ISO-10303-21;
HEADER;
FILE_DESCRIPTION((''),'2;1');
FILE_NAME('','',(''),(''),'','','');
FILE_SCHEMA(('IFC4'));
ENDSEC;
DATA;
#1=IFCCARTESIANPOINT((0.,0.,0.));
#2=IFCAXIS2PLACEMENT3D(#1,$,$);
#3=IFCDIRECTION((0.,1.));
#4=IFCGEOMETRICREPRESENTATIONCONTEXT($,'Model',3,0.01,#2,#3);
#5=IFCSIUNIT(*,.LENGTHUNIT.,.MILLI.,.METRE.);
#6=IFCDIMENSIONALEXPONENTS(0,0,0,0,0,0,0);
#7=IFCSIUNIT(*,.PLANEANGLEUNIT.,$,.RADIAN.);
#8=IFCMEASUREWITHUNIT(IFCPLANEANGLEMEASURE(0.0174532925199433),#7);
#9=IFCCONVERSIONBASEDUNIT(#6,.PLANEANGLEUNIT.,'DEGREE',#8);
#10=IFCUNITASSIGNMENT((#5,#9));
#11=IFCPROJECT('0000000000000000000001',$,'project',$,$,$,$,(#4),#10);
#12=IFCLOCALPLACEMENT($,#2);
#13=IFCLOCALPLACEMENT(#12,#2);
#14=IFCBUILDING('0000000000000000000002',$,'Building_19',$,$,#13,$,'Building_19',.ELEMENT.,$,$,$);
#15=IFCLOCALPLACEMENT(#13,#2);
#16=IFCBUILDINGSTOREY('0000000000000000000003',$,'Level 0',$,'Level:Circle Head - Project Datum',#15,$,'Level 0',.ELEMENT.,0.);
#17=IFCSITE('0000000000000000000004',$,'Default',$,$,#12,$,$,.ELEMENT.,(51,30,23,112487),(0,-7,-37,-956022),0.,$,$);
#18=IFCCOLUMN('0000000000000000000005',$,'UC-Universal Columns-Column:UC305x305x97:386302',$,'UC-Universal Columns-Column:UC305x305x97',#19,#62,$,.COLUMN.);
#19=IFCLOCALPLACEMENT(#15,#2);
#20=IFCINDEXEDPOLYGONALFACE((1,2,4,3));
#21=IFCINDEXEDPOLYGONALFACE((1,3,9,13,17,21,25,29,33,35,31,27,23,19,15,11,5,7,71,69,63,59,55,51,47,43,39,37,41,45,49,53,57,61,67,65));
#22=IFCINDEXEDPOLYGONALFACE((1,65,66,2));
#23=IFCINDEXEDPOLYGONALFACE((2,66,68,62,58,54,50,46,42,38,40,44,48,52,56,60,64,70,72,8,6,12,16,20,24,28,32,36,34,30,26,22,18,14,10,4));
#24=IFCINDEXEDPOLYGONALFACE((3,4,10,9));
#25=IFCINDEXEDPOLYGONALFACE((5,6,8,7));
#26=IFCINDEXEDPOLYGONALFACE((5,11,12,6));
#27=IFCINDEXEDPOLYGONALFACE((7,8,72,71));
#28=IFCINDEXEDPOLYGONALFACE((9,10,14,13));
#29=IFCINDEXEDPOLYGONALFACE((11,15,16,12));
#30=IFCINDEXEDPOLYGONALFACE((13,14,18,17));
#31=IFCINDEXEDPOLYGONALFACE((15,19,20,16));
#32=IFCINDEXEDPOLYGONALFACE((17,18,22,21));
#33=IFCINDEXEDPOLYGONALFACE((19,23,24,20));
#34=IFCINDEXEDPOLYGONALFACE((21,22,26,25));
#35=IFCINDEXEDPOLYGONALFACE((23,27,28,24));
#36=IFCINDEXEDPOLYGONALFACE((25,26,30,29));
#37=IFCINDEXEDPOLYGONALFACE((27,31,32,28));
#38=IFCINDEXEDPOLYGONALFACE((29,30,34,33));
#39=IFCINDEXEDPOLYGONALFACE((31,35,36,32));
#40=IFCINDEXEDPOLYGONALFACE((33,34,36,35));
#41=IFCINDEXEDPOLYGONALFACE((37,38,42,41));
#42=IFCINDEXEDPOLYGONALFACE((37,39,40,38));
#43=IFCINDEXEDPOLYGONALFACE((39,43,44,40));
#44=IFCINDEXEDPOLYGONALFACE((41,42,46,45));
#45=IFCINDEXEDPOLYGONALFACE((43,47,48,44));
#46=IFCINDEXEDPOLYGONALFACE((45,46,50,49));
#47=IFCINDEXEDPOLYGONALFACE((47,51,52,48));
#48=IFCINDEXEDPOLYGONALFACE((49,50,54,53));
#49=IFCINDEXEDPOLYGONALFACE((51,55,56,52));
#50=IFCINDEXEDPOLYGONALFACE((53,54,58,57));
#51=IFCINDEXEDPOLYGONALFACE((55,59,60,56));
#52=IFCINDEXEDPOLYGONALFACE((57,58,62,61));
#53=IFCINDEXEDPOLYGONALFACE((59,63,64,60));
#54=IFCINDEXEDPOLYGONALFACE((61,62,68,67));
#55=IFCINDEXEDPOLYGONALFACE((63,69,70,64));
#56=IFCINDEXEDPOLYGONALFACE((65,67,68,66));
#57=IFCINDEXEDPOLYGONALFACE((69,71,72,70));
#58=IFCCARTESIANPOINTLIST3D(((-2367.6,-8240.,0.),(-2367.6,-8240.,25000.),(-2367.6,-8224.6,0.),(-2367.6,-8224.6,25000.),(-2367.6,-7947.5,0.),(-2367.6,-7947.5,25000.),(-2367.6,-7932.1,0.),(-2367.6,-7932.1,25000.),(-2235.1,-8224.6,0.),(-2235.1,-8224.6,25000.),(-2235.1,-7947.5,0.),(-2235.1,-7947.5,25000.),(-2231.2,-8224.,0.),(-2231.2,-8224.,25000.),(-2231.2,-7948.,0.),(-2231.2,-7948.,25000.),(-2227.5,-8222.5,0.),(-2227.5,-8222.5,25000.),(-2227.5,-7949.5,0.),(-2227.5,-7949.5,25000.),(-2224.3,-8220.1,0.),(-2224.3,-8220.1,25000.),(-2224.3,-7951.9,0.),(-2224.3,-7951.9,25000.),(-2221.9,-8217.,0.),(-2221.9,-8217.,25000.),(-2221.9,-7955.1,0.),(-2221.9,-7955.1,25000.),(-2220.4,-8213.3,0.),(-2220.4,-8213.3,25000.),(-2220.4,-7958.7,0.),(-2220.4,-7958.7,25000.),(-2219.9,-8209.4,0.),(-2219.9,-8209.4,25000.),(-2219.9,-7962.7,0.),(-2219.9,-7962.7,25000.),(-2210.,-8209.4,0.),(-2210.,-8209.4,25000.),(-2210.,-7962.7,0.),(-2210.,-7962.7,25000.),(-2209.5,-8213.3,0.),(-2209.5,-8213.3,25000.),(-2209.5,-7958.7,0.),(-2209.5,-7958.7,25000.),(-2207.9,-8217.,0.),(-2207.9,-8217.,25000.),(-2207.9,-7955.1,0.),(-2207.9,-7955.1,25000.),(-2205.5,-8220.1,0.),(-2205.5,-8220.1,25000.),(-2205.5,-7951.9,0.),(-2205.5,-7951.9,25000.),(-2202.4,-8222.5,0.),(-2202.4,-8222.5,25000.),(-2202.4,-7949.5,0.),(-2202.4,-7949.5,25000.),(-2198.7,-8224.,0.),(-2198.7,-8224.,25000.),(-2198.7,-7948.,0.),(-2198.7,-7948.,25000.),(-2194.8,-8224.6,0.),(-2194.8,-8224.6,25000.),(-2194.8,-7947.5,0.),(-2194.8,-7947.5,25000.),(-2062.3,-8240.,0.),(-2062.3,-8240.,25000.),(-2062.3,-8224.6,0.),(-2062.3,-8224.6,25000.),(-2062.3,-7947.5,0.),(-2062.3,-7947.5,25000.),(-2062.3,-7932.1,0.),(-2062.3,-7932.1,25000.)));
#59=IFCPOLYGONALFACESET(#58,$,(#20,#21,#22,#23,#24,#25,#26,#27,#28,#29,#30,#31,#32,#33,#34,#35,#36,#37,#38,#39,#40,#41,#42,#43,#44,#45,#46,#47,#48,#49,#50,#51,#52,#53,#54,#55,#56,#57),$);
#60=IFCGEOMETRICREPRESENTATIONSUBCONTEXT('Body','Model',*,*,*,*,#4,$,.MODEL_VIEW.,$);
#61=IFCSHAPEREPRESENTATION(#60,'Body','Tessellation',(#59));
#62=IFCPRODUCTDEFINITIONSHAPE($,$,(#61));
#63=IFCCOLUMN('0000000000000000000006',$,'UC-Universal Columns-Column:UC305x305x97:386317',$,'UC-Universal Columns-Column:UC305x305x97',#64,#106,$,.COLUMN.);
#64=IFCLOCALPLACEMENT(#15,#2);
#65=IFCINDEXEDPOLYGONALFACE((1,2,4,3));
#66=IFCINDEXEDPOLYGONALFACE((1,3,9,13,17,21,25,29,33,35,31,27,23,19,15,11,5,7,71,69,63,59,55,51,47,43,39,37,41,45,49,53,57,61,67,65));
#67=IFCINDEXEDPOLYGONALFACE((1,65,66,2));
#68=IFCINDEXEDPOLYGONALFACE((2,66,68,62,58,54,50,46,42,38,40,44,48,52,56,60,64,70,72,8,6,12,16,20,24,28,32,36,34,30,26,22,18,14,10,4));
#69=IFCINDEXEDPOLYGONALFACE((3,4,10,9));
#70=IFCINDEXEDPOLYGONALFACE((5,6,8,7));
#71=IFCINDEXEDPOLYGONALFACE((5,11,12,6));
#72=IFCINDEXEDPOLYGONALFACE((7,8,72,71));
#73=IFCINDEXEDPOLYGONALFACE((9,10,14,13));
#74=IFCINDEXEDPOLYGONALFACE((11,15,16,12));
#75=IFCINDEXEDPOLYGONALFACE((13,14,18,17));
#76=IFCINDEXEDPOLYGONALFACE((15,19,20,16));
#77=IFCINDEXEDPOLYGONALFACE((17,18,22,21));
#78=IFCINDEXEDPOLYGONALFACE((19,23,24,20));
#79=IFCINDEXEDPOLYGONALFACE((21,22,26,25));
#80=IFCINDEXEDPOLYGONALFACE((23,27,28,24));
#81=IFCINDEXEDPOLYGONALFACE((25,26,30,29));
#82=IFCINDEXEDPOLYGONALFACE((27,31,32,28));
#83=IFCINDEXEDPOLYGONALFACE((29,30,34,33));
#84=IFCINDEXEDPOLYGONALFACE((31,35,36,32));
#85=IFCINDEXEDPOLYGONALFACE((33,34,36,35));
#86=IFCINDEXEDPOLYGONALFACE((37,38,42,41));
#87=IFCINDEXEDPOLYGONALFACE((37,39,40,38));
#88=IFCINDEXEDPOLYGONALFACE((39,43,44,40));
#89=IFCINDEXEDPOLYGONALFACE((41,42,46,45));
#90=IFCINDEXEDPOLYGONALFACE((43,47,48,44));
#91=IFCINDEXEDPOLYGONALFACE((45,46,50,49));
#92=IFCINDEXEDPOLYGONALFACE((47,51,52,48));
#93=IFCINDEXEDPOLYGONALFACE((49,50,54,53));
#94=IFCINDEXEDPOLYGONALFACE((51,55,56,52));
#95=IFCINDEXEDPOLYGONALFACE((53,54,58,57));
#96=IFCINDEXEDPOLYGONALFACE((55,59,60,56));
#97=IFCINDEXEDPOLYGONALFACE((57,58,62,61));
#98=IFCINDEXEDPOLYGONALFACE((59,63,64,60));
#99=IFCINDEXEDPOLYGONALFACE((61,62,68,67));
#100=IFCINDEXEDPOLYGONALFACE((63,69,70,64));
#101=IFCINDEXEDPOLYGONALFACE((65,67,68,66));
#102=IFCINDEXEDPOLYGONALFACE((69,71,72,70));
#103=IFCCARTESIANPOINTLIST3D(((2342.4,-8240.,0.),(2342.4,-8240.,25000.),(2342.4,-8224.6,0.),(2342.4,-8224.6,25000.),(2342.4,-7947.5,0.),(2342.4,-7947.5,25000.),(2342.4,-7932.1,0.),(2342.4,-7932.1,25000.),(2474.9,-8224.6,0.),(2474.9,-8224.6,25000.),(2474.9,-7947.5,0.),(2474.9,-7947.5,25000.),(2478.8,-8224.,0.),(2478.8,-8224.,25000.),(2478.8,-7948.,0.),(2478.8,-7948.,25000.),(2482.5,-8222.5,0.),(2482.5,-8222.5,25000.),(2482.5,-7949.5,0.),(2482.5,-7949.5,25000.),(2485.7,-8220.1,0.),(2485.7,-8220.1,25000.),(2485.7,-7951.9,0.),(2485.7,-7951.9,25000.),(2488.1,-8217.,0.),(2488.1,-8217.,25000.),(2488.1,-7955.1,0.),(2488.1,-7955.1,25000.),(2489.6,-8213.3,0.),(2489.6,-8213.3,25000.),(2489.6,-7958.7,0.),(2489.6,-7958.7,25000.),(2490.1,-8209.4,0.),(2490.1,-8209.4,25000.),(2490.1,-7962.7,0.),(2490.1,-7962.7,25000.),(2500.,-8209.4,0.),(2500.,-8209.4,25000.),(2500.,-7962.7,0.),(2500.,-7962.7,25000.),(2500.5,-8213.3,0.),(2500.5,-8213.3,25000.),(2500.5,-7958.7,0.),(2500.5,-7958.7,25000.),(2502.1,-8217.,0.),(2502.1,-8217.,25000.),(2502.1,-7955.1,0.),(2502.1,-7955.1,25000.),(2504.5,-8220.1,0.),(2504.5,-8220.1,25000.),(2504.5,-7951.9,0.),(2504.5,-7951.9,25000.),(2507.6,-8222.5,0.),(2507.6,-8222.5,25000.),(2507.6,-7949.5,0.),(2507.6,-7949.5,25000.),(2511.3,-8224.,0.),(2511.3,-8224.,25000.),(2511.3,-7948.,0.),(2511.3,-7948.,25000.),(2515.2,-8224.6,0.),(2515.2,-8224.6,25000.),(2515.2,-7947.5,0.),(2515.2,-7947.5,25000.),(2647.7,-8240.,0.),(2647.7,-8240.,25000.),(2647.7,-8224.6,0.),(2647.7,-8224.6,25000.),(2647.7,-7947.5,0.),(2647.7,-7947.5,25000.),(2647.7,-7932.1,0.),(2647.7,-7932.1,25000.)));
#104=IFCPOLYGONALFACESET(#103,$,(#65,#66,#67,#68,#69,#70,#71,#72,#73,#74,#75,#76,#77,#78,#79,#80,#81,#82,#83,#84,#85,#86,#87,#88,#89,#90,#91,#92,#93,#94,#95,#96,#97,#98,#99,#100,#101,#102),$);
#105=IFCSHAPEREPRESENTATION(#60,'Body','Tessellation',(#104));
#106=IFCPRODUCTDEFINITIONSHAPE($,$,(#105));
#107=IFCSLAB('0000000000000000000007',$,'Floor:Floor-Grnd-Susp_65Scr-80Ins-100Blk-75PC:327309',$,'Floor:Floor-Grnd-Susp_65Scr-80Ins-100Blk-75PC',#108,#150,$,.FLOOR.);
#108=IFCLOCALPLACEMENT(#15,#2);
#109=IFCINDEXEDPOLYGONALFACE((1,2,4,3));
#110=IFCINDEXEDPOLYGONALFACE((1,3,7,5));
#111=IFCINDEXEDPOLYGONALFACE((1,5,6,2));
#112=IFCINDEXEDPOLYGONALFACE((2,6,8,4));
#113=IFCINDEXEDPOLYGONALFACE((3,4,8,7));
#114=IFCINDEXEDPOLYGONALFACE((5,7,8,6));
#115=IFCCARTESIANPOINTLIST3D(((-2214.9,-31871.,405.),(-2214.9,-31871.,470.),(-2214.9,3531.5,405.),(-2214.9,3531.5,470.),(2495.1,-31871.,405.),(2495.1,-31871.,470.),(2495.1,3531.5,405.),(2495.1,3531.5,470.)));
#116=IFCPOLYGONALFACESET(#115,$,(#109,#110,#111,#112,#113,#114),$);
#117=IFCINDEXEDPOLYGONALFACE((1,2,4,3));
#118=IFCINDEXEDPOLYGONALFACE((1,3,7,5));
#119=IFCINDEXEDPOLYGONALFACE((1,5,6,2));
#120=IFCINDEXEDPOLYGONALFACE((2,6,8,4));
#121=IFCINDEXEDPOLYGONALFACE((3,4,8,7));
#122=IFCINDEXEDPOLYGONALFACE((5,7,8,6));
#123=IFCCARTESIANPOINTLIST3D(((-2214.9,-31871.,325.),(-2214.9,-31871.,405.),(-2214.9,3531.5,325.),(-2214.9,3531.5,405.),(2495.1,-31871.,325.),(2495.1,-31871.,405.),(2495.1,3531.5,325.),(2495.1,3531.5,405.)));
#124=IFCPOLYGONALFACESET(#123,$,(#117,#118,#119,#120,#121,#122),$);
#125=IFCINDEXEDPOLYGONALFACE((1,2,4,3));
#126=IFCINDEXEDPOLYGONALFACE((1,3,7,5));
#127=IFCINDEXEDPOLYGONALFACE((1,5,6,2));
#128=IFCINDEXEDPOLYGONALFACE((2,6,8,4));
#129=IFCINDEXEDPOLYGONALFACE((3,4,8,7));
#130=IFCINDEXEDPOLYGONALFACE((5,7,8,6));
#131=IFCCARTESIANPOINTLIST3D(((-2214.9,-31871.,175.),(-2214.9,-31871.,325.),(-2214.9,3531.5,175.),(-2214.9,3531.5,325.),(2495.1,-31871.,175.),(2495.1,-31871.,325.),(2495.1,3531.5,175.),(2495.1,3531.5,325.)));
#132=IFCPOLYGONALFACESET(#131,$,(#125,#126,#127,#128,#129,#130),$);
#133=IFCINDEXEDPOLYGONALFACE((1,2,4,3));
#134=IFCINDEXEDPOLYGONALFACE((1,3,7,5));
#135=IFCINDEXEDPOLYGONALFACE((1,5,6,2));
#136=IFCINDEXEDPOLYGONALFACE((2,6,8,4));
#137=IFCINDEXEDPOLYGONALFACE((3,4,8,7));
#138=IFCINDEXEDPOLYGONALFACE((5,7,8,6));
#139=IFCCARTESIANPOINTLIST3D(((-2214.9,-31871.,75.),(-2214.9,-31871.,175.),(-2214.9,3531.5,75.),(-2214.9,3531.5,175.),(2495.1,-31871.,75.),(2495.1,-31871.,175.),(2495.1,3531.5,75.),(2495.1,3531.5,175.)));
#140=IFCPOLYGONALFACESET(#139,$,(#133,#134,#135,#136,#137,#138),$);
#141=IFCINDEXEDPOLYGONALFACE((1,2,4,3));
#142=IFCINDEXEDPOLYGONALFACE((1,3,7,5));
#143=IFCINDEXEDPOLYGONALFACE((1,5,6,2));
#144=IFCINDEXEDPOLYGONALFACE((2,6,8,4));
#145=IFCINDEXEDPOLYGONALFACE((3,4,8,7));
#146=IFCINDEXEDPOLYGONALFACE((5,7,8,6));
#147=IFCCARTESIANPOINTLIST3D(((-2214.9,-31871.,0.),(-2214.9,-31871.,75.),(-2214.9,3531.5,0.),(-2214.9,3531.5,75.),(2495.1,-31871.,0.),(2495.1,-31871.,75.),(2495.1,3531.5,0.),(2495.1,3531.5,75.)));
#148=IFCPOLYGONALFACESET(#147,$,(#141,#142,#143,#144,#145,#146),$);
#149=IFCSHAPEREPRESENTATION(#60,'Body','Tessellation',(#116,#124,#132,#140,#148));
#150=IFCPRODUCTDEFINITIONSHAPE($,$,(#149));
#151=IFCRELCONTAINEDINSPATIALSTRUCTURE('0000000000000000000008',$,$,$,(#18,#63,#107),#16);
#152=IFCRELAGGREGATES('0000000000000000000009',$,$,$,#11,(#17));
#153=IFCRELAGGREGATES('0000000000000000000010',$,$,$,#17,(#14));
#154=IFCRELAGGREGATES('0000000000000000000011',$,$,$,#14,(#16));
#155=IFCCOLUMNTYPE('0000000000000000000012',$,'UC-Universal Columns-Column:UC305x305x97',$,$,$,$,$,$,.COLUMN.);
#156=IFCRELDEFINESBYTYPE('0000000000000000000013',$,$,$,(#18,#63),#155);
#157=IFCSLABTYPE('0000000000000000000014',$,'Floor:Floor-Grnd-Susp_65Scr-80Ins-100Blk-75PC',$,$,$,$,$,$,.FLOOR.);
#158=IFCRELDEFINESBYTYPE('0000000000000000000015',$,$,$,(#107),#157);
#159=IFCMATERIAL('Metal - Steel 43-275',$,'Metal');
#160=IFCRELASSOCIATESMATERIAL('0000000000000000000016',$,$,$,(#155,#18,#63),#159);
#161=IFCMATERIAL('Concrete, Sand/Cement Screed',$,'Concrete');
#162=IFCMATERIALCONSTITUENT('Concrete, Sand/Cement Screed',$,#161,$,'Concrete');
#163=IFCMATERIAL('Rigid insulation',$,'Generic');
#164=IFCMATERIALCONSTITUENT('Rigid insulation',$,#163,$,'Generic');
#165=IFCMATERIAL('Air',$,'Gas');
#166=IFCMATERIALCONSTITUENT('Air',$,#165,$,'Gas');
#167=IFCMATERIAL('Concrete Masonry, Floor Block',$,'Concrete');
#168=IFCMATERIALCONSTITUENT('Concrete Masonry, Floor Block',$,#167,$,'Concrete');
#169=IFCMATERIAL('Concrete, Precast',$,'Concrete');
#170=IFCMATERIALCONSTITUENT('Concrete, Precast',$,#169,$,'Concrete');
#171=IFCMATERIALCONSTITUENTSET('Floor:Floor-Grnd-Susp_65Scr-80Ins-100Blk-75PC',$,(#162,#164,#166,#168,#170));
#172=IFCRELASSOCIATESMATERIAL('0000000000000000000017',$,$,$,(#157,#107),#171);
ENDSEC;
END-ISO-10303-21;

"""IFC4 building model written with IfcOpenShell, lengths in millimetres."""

from ifc_helpers import new_model, entity, si_unit, converted_unit, direction, frame, origin, place, context, subcontext, project, spatial, line, arc, indexed_curve, outline, extrude, source, transform, mapped, material, constituent, constituent_set, type_object, type_shapes, element, save


model = new_model("IFC4")

# Units and contexts
model_context = context("Model", 3, precision=0.01, world=origin(), true_north=direction((0.0, 1.0)))
body_context = subcontext(model_context, "Body", "Model", "MODEL_VIEW")
ifc_project = project(units=[si_unit("LENGTHUNIT", "METRE", prefix="MILLI"), converted_unit("PLANEANGLEUNIT", "DEGREE", entity("IfcPlaneAngleMeasure", 0.0174532925199433), si_unit("PLANEANGLEUNIT", "RADIAN"), dimensions=[0, 0, 0, 0, 0, 0, 0])], contexts=[model_context])

# Site, building, storey
site_placement = place(None, origin())
site = spatial("IfcSite", under=ifc_project, at=site_placement, Name="Default", CompositionType="ELEMENT", RefLatitude=(51, 30, 23, 112487), RefLongitude=(0, -7, -37, -956022), RefElevation=0.0)
building_placement = place(site_placement, origin())
building = spatial("IfcBuilding", under=site, at=building_placement, Name="Building_19", LongName="Building_19", CompositionType="ELEMENT")
storey_placement = place(building_placement, origin())
storey = spatial("IfcBuildingStorey", under=building, at=storey_placement, Name="Level 0", ObjectType="Level:Circle Head - Project Datum", LongName="Level 0", CompositionType="ELEMENT", Elevation=0.0)

# Columns
ifc_material_1 = material(Name="Metal - Steel 43-275", Category="Metal")
column_type = type_object("IfcColumnType", Name="UC-Universal Columns-Column:UC305x305x97", PredefinedType="COLUMN", material=ifc_material_1)
shared_shape_1 = source(origin(), body_context, "Body", "SweptSolid", [
    extrude(outline(indexed_curve([(-152.7, -153.9), (152.7, -153.9), (152.7, -138.6), (20.2, -138.6), (9.4, -134.1), (4.9, -123.3), (4.9, 123.3), (9.4, 134.1), (20.1, 138.6), (152.7, 138.6), (152.7, 153.9), (-152.7, 153.9), (-152.7, 138.6), (-20.2, 138.6), (-9.4, 134.1), (-5.0, 123.3), (-5.0, -123.3), (-9.4, -134.1), (-20.2, -138.6), (-152.7, -138.6)], segments=[line(1, 2, 3, 4), arc(4, 5, 6), line(6, 7), arc(7, 8, 9), line(9, 10, 11, 12, 13, 14), arc(14, 15, 16), line(16, 17), arc(17, 18, 19), line(19, 20, 1)], self_intersect=False)), frame((0.0, 0.0, 0.0), z_axis=(0.0, 0.0, 1.0), x_axis=(-1.0, 0.0, 0.0)), (0.0, 0.0, 1.0), 25000.0),
])
type_shapes(column_type, [shared_shape_1])
for number, where, name in (
    (1, (-2214.9, -8086.0, 0.0), "UC-Universal Columns-Column:UC305x305x97:386302"),
    (2, (2495.1, -8086.0, 0.0), "UC-Universal Columns-Column:UC305x305x97:386317"),
):
    element("IfcColumn", number, at=place(storey_placement, frame(where)), inside=storey, type_object=column_type, material=ifc_material_1, Name=name, ObjectType="UC-Universal Columns-Column:UC305x305x97", PredefinedType="COLUMN", context=body_context, shape_type="MappedRepresentation", body=[
        mapped(shared_shape_1, transform((0.0, 0.0, 0.0), scale=1.0)),
    ])

# Slab
ifc_material_2 = material(Name="Concrete, Sand/Cement Screed", Category="Concrete")
ifc_constituent_1 = constituent(ifc_material_2, Name="Concrete, Sand/Cement Screed", Category="Concrete")
ifc_material_3 = material(Name="Rigid insulation", Category="Generic")
ifc_constituent_2 = constituent(ifc_material_3, Name="Rigid insulation", Category="Generic")
ifc_material_4 = material(Name="Air", Category="Gas")
ifc_constituent_3 = constituent(ifc_material_4, Name="Air", Category="Gas")
ifc_material_5 = material(Name="Concrete Masonry, Floor Block", Category="Concrete")
ifc_constituent_4 = constituent(ifc_material_5, Name="Concrete Masonry, Floor Block", Category="Concrete")
ifc_material_6 = material(Name="Concrete, Precast", Category="Concrete")
ifc_constituent_5 = constituent(ifc_material_6, Name="Concrete, Precast", Category="Concrete")
ifc_constituent_set_1 = constituent_set(constituents=[ifc_constituent_1, ifc_constituent_2, ifc_constituent_3, ifc_constituent_4, ifc_constituent_5], Name="Floor:Floor-Grnd-Susp_65Scr-80Ins-100Blk-75PC")
slab_type = type_object("IfcSlabType", Name="Floor:Floor-Grnd-Susp_65Scr-80Ins-100Blk-75PC", PredefinedType="FLOOR", material=ifc_constituent_set_1)
slab_1_placement = place(storey_placement, origin())
element("IfcSlab", 3, at=slab_1_placement, inside=storey, type_object=slab_type, material=ifc_constituent_set_1, Name="Floor:Floor-Grnd-Susp_65Scr-80Ins-100Blk-75PC:327309", ObjectType="Floor:Floor-Grnd-Susp_65Scr-80Ins-100Blk-75PC", PredefinedType="FLOOR", context=body_context, shape_type="SweptSolid", body=[
    extrude(outline(indexed_curve([(-17701.2, -2355.0), (17701.2, -2355.0), (17701.2, 2355.0), (-17701.2, 2355.0), (-17701.2, -2355.0)], self_intersect=False)), frame((140.1, -14169.8, 405.0), z_axis=(0.0, 0.0, 1.0), x_axis=(0.0, -1.0, 0.0)), (0.0, 0.0, 1.0), 65.0),
    extrude(outline(indexed_curve([(-17701.2, -2355.0), (17701.2, -2355.0), (17701.2, 2355.0), (-17701.2, 2355.0), (-17701.2, -2355.0)], self_intersect=False)), frame((140.1, -14169.8, 325.0), z_axis=(0.0, 0.0, 1.0), x_axis=(0.0, -1.0, 0.0)), (0.0, 0.0, 1.0), 80.0),
    extrude(outline(indexed_curve([(-17701.2, -2355.0), (17701.2, -2355.0), (17701.2, 2355.0), (-17701.2, 2355.0), (-17701.2, -2355.0)], self_intersect=False)), frame((140.1, -14169.8, 175.0), z_axis=(0.0, 0.0, 1.0), x_axis=(0.0, -1.0, 0.0)), (0.0, 0.0, 1.0), 150.0),
    extrude(outline(indexed_curve([(-17701.2, -2355.0), (17701.2, -2355.0), (17701.2, 2355.0), (-17701.2, 2355.0), (-17701.2, -2355.0)], self_intersect=False)), frame((140.1, -14169.8, 75.0), z_axis=(0.0, 0.0, 1.0), x_axis=(0.0, -1.0, 0.0)), (0.0, 0.0, 1.0), 100.0),
    extrude(outline(indexed_curve([(-17701.2, -2355.0), (17701.2, -2355.0), (17701.2, 2355.0), (-17701.2, 2355.0), (-17701.2, -2355.0)], self_intersect=False)), frame((140.1, -14169.8, 0.0), z_axis=(0.0, 0.0, 1.0), x_axis=(0.0, -1.0, 0.0)), (0.0, 0.0, 1.0), 75.0),
])

save(model, "model.ifc")
